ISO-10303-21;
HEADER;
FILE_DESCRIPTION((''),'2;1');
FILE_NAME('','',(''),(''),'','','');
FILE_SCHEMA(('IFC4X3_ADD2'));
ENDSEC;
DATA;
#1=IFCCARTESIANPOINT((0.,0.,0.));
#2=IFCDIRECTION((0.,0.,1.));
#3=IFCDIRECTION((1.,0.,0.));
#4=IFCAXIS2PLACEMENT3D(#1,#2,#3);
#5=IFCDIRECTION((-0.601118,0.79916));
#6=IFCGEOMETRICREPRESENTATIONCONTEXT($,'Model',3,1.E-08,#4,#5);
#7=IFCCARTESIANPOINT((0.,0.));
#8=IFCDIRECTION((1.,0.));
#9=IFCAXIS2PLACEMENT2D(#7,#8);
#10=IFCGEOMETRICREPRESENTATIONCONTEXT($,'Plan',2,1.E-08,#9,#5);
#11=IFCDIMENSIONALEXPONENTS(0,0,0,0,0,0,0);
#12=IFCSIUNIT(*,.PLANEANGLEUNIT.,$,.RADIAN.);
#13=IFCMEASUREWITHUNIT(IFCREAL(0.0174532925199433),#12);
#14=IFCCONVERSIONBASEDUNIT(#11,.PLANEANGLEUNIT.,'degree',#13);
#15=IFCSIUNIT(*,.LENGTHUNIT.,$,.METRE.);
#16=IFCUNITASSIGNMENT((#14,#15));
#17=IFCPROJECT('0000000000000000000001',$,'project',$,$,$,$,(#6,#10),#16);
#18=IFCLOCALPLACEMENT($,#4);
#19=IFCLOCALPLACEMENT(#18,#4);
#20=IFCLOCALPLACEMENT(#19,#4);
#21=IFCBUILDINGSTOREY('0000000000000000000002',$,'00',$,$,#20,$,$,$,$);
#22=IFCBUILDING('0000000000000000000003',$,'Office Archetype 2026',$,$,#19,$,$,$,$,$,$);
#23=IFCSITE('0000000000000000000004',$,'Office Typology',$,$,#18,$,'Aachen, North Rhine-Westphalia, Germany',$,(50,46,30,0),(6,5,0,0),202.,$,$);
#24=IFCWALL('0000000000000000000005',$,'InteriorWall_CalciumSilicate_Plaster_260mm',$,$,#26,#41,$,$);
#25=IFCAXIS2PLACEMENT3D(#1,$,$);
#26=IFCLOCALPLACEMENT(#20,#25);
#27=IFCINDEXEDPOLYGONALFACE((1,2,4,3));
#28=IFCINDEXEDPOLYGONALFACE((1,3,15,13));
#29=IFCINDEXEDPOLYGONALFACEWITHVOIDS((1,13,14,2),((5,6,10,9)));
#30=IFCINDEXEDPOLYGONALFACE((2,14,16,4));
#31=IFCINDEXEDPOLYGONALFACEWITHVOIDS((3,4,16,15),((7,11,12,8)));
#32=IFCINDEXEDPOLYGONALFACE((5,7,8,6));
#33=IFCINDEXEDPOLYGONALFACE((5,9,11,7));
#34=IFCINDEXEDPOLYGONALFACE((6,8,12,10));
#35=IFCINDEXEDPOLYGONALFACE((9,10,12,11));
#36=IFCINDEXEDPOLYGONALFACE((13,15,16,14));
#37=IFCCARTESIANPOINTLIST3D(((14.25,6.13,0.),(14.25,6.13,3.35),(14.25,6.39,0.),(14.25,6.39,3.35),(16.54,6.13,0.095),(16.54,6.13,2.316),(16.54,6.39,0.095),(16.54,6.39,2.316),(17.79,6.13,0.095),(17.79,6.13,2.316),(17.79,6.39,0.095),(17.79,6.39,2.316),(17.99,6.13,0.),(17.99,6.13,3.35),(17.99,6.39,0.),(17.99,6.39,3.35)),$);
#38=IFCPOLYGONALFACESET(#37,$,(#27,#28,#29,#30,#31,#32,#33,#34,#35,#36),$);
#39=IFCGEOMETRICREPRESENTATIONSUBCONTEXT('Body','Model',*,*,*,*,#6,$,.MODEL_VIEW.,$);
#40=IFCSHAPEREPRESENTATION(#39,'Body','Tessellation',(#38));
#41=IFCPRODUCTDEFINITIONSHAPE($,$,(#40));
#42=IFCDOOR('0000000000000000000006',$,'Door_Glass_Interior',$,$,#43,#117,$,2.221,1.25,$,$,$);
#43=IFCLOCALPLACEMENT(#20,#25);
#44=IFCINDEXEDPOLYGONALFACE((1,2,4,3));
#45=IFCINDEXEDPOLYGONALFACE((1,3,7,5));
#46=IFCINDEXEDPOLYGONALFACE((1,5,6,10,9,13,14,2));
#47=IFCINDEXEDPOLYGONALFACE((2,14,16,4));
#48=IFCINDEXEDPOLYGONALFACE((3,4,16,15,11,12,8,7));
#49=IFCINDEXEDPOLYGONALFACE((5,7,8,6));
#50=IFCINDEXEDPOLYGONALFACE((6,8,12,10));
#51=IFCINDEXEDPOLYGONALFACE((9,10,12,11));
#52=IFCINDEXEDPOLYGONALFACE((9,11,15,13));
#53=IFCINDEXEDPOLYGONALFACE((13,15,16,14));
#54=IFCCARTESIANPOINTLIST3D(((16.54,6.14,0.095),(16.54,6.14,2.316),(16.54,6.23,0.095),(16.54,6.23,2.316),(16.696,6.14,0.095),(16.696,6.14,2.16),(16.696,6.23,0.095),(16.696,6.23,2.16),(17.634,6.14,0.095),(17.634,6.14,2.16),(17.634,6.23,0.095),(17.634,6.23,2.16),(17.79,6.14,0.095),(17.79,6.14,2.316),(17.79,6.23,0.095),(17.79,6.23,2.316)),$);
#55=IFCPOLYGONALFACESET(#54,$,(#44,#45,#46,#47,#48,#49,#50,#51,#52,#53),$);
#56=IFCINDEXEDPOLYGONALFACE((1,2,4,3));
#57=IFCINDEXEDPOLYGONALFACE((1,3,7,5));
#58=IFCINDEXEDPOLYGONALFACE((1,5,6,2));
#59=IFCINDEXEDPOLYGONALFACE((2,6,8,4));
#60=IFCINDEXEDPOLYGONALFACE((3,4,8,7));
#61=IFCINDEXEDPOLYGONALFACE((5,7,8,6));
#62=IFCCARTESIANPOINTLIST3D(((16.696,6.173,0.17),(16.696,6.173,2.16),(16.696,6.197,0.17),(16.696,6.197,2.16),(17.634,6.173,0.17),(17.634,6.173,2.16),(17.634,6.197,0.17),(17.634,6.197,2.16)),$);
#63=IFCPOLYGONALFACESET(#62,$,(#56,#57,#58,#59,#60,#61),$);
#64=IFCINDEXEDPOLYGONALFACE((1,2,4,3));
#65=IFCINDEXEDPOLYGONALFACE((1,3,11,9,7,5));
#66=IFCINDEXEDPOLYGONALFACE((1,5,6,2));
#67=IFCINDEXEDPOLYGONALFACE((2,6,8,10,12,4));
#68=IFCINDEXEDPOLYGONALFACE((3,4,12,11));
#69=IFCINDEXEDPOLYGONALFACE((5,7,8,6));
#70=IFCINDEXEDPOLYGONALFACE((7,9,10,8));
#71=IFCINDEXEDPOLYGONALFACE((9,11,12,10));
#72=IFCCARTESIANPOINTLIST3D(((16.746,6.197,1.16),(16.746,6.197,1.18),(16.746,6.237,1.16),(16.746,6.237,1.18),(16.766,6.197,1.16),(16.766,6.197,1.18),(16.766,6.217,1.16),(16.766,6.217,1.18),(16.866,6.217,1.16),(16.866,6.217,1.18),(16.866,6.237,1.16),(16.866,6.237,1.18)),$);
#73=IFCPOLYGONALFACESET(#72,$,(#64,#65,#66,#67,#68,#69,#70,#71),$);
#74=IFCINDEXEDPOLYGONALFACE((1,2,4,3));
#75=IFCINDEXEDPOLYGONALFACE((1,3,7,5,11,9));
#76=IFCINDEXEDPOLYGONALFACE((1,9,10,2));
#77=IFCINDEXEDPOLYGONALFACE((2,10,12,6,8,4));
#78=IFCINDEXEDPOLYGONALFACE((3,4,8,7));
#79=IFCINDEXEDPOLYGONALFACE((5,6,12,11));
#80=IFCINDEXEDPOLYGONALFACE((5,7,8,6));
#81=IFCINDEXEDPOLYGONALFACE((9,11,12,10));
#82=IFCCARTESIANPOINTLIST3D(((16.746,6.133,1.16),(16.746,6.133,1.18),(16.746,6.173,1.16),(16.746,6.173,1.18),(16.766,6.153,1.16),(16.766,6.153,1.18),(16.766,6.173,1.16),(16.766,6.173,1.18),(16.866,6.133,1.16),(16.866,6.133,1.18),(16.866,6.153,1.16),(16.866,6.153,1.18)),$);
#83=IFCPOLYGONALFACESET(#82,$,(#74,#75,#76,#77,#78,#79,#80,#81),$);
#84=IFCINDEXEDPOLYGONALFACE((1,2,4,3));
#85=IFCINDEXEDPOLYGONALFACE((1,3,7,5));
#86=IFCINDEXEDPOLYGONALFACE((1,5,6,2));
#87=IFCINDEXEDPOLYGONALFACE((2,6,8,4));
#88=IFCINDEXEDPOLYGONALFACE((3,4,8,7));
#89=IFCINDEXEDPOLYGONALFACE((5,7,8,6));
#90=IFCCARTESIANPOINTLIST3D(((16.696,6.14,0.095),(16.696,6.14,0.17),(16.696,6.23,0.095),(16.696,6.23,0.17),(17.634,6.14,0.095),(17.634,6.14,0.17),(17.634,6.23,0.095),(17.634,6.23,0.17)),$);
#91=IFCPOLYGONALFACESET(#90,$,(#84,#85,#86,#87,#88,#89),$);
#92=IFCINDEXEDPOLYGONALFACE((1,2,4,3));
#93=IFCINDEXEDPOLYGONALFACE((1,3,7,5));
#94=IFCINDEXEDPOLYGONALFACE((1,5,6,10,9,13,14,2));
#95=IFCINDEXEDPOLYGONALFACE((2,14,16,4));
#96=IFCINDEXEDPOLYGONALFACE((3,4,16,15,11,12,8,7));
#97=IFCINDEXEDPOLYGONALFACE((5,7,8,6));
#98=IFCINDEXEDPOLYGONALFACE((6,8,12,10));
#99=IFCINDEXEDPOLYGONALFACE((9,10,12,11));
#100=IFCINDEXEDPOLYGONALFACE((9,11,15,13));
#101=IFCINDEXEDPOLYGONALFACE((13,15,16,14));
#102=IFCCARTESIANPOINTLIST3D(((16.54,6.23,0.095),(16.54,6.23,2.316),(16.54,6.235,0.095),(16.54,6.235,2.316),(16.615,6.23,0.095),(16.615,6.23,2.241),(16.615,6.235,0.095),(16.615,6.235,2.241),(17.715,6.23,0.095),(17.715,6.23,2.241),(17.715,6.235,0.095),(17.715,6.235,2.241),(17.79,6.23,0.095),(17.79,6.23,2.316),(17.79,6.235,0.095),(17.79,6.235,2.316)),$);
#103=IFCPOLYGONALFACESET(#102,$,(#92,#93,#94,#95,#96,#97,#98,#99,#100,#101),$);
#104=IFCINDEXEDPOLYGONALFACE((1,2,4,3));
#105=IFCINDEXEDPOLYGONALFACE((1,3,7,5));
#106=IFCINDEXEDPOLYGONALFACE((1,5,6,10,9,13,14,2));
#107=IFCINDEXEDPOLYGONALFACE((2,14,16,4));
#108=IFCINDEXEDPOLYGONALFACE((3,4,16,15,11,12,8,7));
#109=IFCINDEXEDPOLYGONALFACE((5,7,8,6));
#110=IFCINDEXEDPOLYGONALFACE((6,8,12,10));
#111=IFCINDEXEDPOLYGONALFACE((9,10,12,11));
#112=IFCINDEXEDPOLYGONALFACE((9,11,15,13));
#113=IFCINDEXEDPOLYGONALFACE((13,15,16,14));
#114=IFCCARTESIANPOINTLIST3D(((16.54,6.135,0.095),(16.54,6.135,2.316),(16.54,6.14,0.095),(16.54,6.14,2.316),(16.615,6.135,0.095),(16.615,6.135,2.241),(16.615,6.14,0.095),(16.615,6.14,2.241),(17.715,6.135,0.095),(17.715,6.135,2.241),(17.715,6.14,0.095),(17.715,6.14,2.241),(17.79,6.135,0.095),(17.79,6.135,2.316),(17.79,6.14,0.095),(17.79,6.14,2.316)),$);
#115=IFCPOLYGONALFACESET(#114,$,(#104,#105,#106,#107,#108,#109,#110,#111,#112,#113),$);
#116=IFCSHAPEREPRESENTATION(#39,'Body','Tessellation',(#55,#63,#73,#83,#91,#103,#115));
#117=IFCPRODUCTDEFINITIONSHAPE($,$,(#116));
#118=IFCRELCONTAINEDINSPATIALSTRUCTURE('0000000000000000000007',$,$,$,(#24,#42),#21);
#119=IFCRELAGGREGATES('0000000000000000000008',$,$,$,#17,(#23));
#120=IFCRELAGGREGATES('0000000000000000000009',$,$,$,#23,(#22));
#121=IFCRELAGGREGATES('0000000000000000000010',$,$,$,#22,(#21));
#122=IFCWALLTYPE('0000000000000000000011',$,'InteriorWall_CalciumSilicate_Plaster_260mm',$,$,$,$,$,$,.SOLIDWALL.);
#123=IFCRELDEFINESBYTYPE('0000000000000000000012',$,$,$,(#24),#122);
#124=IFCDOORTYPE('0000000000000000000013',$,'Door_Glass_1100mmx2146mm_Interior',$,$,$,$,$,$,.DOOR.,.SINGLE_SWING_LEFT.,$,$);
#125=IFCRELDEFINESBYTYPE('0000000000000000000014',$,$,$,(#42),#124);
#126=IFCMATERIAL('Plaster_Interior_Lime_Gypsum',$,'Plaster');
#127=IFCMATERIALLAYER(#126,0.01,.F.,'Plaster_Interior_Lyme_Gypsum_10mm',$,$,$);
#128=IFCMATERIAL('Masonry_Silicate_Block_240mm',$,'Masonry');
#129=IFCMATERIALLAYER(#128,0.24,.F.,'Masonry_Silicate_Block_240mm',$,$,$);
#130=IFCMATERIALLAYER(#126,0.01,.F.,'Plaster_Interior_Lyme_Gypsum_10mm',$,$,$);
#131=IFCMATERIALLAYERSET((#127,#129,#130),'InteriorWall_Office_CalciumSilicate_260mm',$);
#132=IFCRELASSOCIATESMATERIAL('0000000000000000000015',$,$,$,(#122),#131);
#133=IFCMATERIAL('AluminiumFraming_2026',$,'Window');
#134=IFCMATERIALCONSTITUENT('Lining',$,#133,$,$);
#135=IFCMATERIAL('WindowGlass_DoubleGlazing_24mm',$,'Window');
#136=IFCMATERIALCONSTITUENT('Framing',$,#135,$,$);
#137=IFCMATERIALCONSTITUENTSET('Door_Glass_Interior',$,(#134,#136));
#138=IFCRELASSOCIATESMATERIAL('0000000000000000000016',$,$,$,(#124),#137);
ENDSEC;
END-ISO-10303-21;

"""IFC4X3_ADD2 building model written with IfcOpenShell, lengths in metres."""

from ifc_helpers import new_model, entity, si_unit, converted_unit, direction, frame, origin_with_axes, origin_2d_with_axis, place, context, subcontext, project, spatial, line, indexed_curve, outline, extrude, source, transform, mapped, material, layer, layer_set, constituent, constituent_set, type_object, type_shapes, element, fill, save


model = new_model("IFC4X3_ADD2")

# Units and contexts
model_context = context("Model", 3, precision=1e-08, world=origin_with_axes(), true_north=direction((-0.601118, 0.79916)))
plan_context = context("Plan", 2, precision=1e-08, world=origin_2d_with_axis(), true_north=direction((-0.601118, 0.79916)))
body_context = subcontext(model_context, "Body", "Model", "MODEL_VIEW")
ifc_project = project(units=[converted_unit("PLANEANGLEUNIT", "degree", entity("IfcReal", 0.0174532925199433), si_unit("PLANEANGLEUNIT", "RADIAN"), dimensions=[0, 0, 0, 0, 0, 0, 0]), si_unit("LENGTHUNIT", "METRE")], contexts=[model_context, plan_context])

# Site, building, storey
site_placement = place(None, origin_with_axes())
site = spatial("IfcSite", under=ifc_project, at=site_placement, Name="Office Typology", LongName="Aachen, North Rhine-Westphalia, Germany", RefLatitude=(50, 46, 30, 0), RefLongitude=(6, 5, 0, 0), RefElevation=202.0)
building_placement = place(site_placement, origin_with_axes())
building = spatial("IfcBuilding", under=site, at=building_placement, Name="Office Archetype 2026")
storey_placement = place(building_placement, origin_with_axes())
storey = spatial("IfcBuildingStorey", under=building, at=storey_placement, Name="00")

# Shared definitions
ifc_material_1 = material(Name="Plaster_Interior_Lime_Gypsum", Category="Plaster")
ifc_layer_1 = layer(ifc_material_1, 0.01, ventilated=False, Name="Plaster_Interior_Lyme_Gypsum_10mm")
ifc_material_2 = material(Name="Masonry_Silicate_Block_240mm", Category="Masonry")
ifc_layer_2 = layer(ifc_material_2, 0.24, ventilated=False, Name="Masonry_Silicate_Block_240mm")
ifc_layer_3 = layer(ifc_material_1, 0.01, ventilated=False, Name="Plaster_Interior_Lyme_Gypsum_10mm")
ifc_layer_set = layer_set([ifc_layer_1, ifc_layer_2, ifc_layer_3], Name="InteriorWall_Office_CalciumSilicate_260mm")
wall_type = type_object("IfcWallType", Name="InteriorWall_CalciumSilicate_Plaster_260mm", PredefinedType="SOLIDWALL", material=ifc_layer_set)

# Wall, opening, door
wall_1_placement = place(storey_placement, frame((18.25, 6.39, 0.0), z_axis=(0.0, 0.0, 1.0), x_axis=(-1.0, 0.0, 0.0)))
wall_1 = element("IfcWall", 1, at=wall_1_placement, inside=storey, type_object=wall_type, Name="InteriorWall_CalciumSilicate_Plaster_260mm", context=body_context, shape_type="SweptSolid", body=[
    extrude(outline(indexed_curve([(0.26, 0.0), (0.26, 0.26), (4.0, 0.26), (4.0, 0.0), (0.26, 0.0)])), origin_with_axes(), (0.0, 0.0, 1.0), 3.35),
])
shared_shape_1 = source(origin_with_axes(), body_context, "Body", "SweptSolid", [
    extrude(outline(indexed_curve([(0.0, 2.221), (1.25, 2.221), (1.25, 0.0), (0.0, 0.0), (0.0, 2.221)])), frame((0.0, -0.16, 0.0), z_axis=(0.0, -1.0, 0.0), x_axis=(1.0, 0.0, 0.0)), (0.0, 0.0, -1.0), 0.26),
])
opening_1_placement = place(wall_1_placement, frame((0.46, 0.16, 0.095), z_axis=(0.0, 0.0, 1.0), x_axis=(1.0, 0.0, 0.0)))
opening_1 = element("IfcOpeningElement", 2, at=opening_1_placement, cuts=wall_1, PredefinedType="OPENING", context=body_context, shape_type="MappedRepresentation", body=[
    mapped(shared_shape_1, transform((0.0, 0.0, 0.0), x_axis=(1.0, 0.0, 0.0), y_axis=(0.0, 1.0, 0.0), z_axis=(0.0, 0.0, 1.0), scale=1.0)),
])
ifc_material_3 = material(Name="AluminiumFraming_2026", Category="Window")
ifc_constituent_1 = constituent(ifc_material_3, Name="Lining")
ifc_material_4 = material(Name="WindowGlass_DoubleGlazing_24mm", Category="Window")
ifc_constituent_2 = constituent(ifc_material_4, Name="Framing")
ifc_constituent_set_1 = constituent_set(constituents=[ifc_constituent_1, ifc_constituent_2], Name="Door_Glass_Interior")
door_type_1 = type_object("IfcDoorType", Name="Door_Glass_1100mmx2146mm_Interior", OperationType="SINGLE_SWING_LEFT", PredefinedType="DOOR", material=ifc_constituent_set_1)
shared_shape_2 = source(origin_with_axes(), body_context, "Body", "SweptSolid", [
    extrude(outline(indexed_curve([(0.0, 0.0), (0.0, 2.221), (1.25, 2.221), (1.25, 0.0), (1.094, 0.0), (1.094, 2.065), (0.156, 2.065), (0.156, 0.0)], segments=[line(1, 2, 3, 4, 5, 6, 7, 8, 1)])), frame((0.0, 0.0, 0.0), z_axis=(0.0, -1.0, 0.0), x_axis=(1.0, 0.0, 0.0)), (0.0, 0.0, -1.0), 0.09),
    extrude(outline(indexed_curve([(0.0, 0.0), (0.938, 0.0), (0.938, 0.024), (0.0, 0.024)], segments=[line(1, 2, 3, 4, 1)])), frame((0.156, 0.033, 0.075), z_axis=(0.0, 0.0, 1.0), x_axis=(1.0, 0.0, 0.0)), (0.0, 0.0, 1.0), 1.99),
    extrude(outline(indexed_curve([(0.0, 0.0), (0.0, -0.04), (-0.12, -0.04), (-0.12, -0.02), (-0.02, -0.02), (-0.02, 0.0)], segments=[line(1, 2, 3, 4, 5, 6, 1)])), frame((1.044, 0.033, 1.065), z_axis=(0.0, 0.0, 1.0), x_axis=(1.0, 0.0, 0.0)), (0.0, 0.0, 1.0), 0.02),
    extrude(outline(indexed_curve([(0.0, 0.0), (0.0, 0.04), (-0.12, 0.04), (-0.12, 0.02), (-0.02, 0.02), (-0.02, 0.0)], segments=[line(1, 2, 3, 4, 5, 6, 1)])), frame((1.044, 0.057, 1.065), z_axis=(0.0, 0.0, 1.0), x_axis=(1.0, 0.0, 0.0)), (0.0, 0.0, 1.0), 0.02),
    extrude(outline(indexed_curve([(0.0, 0.0), (0.938, 0.0), (0.938, 0.09), (0.0, 0.09)], segments=[line(1, 2, 3, 4, 1)])), frame((0.156, 0.0, 0.0), z_axis=(0.0, 0.0, 1.0), x_axis=(1.0, 0.0, 0.0)), (0.0, 0.0, 1.0), 0.075),
    extrude(outline(indexed_curve([(0.0, 0.0), (0.0, 2.221), (1.25, 2.221), (1.25, 0.0), (1.175, 0.0), (1.175, 2.146), (0.075, 2.146), (0.075, 0.0)], segments=[line(1, 2, 3, 4, 5, 6, 7, 8, 1)])), frame((0.0, -0.005, 0.0), z_axis=(0.0, -1.0, 0.0), x_axis=(1.0, 0.0, 0.0)), (0.0, 0.0, -1.0), 0.005),
    extrude(outline(indexed_curve([(0.0, 0.0), (0.0, 2.221), (1.25, 2.221), (1.25, 0.0), (1.175, 0.0), (1.175, 2.146), (0.075, 2.146), (0.075, 0.0)], segments=[line(1, 2, 3, 4, 5, 6, 7, 8, 1)])), frame((0.0, 0.09, 0.0), z_axis=(0.0, -1.0, 0.0), x_axis=(1.0, 0.0, 0.0)), (0.0, 0.0, -1.0), 0.005),
])
type_shapes(door_type_1, [shared_shape_2])
door_1_placement = place(opening_1_placement, origin_with_axes())
door_1 = element("IfcDoor", 3, at=door_1_placement, inside=storey, type_object=door_type_1, Name="Door_Glass_Interior", OverallHeight=2.221, OverallWidth=1.25, context=body_context, shape_type="MappedRepresentation", body=[
    mapped(shared_shape_2, transform((0.0, 0.0, 0.0), x_axis=(1.0, 0.0, 0.0), y_axis=(0.0, 1.0, 0.0), z_axis=(0.0, 0.0, 1.0), scale=1.0)),
])
fill(opening_1, door_1)

save(model, "model.ifc")
